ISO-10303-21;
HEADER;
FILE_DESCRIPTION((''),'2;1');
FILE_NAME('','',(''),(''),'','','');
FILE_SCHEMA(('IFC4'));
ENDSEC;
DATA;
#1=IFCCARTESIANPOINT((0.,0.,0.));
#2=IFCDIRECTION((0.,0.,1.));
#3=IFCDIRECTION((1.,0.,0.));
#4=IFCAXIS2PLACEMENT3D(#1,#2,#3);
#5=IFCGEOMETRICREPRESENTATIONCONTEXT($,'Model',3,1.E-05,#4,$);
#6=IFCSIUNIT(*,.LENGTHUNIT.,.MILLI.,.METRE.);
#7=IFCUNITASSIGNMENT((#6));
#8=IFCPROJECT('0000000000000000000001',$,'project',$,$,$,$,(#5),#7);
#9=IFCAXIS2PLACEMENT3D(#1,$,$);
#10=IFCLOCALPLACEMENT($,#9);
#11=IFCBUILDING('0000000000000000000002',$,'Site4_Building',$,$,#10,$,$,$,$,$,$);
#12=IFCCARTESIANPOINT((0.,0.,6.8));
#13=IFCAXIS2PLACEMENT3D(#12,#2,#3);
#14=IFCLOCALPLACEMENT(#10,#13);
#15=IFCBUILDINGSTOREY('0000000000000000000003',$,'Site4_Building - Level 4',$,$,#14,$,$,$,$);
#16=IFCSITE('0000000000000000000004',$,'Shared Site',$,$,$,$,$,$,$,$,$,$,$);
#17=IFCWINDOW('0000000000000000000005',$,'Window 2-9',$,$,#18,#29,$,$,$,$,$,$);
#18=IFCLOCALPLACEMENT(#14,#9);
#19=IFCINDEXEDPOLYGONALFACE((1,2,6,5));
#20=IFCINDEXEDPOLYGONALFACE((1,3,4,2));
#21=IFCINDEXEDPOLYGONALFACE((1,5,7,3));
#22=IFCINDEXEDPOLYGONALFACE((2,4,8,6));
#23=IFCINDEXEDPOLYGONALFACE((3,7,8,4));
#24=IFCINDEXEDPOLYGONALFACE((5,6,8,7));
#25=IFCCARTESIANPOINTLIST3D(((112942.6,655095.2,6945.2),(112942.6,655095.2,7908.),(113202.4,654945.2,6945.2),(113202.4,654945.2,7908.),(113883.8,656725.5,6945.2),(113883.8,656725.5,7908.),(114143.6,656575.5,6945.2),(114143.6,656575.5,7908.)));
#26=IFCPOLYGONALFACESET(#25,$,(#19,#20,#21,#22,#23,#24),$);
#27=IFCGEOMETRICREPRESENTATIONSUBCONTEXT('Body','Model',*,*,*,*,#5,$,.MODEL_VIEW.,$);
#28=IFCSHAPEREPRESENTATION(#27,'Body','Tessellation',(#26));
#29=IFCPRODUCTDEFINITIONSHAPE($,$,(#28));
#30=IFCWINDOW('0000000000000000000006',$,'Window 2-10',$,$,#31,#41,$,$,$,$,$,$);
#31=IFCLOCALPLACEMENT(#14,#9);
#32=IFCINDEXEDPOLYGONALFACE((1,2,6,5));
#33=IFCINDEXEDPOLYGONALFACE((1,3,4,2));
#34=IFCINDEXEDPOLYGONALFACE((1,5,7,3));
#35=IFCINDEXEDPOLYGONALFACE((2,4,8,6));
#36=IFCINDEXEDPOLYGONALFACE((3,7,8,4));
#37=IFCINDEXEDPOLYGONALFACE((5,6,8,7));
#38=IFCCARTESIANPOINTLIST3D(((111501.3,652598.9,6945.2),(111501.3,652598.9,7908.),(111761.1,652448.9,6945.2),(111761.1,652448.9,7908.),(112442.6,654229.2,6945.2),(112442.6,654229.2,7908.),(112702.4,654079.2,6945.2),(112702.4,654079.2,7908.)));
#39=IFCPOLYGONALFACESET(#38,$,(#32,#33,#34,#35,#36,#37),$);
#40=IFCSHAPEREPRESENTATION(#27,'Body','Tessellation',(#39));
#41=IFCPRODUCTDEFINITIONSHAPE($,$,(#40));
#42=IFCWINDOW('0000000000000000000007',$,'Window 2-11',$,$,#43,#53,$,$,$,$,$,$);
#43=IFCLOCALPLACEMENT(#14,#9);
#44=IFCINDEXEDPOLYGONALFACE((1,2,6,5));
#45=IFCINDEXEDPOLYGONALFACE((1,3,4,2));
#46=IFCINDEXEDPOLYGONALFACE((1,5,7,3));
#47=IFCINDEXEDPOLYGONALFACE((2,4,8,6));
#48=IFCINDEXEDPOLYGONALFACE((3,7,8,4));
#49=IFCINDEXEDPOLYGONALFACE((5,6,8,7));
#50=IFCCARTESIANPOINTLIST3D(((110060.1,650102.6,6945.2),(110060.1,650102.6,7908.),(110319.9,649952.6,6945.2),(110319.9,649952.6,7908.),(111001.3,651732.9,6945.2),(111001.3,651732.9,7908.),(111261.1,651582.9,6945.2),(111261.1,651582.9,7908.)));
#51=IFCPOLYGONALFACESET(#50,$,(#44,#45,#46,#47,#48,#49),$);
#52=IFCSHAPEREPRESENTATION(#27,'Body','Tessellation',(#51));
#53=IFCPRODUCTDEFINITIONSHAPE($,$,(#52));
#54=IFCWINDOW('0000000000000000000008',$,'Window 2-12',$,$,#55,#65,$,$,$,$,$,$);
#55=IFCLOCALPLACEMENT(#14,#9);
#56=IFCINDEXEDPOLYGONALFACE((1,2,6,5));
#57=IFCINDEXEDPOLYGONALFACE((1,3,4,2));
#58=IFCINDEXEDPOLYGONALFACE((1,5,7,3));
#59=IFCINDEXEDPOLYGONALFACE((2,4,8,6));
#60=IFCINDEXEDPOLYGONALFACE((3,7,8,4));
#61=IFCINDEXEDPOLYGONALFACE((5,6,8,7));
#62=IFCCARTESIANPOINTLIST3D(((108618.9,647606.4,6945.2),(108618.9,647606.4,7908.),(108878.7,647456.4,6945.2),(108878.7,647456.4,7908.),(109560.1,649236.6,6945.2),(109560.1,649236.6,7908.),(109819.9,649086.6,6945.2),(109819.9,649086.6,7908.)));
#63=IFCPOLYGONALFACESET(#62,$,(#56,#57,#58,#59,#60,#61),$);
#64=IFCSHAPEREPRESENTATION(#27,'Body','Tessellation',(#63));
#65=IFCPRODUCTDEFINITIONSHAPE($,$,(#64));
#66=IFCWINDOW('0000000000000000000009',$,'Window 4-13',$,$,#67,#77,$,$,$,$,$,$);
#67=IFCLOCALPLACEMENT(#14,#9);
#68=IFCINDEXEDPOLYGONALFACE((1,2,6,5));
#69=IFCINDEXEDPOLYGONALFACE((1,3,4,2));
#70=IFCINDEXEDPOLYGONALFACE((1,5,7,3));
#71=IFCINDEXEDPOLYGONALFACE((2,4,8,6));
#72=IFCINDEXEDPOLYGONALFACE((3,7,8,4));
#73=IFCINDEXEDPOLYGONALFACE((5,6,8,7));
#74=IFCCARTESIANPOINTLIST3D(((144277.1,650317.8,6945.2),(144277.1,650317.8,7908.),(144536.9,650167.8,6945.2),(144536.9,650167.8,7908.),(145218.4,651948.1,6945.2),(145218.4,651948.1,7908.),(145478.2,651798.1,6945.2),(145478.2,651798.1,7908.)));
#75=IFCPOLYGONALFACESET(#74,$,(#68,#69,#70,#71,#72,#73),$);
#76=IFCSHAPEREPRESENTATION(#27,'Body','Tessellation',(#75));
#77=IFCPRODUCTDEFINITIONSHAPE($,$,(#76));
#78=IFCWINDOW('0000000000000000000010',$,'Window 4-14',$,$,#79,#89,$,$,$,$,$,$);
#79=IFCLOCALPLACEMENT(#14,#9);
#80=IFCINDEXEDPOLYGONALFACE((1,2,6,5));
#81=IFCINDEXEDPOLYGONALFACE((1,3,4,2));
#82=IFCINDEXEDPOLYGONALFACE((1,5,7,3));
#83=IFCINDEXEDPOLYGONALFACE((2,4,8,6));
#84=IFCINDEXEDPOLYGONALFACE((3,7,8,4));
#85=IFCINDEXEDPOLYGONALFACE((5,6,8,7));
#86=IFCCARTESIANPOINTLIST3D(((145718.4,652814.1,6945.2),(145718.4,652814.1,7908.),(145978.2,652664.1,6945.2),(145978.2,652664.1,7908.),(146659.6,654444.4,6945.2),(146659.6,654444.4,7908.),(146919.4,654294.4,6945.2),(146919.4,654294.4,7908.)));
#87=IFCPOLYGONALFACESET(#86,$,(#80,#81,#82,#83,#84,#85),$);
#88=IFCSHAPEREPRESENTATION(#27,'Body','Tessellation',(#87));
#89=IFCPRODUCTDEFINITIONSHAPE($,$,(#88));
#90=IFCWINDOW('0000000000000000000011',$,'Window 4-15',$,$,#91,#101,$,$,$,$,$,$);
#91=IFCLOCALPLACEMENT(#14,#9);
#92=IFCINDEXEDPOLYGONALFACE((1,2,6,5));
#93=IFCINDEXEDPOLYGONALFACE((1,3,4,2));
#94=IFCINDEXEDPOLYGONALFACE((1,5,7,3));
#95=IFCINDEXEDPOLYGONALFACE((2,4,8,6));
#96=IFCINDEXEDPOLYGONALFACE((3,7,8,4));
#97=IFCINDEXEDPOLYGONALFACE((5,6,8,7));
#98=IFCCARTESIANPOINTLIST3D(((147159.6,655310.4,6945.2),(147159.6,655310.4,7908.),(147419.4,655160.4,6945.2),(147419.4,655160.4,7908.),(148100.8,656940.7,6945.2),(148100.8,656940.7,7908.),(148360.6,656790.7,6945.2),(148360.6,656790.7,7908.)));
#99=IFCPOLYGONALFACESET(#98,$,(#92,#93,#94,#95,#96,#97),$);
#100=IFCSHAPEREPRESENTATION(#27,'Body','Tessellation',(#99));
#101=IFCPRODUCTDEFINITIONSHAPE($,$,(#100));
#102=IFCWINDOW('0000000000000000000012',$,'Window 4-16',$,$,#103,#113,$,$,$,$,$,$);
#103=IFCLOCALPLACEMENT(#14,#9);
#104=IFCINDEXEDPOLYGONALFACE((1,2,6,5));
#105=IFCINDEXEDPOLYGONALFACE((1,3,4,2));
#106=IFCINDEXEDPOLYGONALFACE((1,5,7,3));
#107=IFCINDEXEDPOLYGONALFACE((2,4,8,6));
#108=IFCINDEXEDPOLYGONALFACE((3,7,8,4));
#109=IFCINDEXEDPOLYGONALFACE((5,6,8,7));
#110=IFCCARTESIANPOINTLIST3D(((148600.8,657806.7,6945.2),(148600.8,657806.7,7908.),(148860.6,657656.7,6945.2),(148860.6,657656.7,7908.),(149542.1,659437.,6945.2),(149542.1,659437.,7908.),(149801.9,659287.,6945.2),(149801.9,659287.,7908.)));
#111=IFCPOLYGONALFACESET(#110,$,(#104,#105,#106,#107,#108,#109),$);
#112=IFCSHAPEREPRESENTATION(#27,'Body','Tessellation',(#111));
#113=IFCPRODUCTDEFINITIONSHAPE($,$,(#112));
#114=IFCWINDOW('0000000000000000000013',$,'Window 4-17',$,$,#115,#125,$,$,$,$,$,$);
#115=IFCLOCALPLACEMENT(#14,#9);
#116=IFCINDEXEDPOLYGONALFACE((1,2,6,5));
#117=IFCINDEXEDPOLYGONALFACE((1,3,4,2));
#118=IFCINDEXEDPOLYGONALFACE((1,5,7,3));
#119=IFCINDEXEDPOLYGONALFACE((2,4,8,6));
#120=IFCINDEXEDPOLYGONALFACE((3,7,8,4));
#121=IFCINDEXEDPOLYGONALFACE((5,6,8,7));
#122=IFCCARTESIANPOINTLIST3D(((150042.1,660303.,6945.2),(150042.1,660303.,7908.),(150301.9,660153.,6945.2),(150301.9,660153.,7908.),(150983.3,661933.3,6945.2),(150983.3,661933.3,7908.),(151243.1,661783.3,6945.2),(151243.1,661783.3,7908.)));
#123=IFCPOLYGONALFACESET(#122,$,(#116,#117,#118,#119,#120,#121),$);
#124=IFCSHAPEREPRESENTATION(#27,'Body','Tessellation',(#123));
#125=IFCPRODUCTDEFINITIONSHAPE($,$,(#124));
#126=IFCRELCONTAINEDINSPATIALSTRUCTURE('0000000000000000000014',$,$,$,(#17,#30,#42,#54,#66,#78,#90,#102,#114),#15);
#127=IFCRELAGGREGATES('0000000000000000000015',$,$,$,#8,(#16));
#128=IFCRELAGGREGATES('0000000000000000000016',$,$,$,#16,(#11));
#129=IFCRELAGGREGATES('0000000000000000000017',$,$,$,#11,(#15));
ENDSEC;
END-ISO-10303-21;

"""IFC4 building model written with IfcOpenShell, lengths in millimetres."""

from ifc_helpers import new_model, si_unit, frame, origin, origin_with_axes, place, context, subcontext, project, spatial, indexed_curve, outline, extrude, element, save


model = new_model("IFC4")

# Units and contexts
model_context = context("Model", 3, precision=1e-05, world=origin_with_axes())
body_context = subcontext(model_context, "Body", "Model", "MODEL_VIEW")
ifc_project = project(units=[si_unit("LENGTHUNIT", "METRE", prefix="MILLI")], contexts=[model_context])

# Site, building, storey
site = spatial("IfcSite", under=ifc_project, Name="Shared Site")
building_placement = place(None, origin())
building = spatial("IfcBuilding", under=site, at=building_placement, Name="Site4_Building")
storey_placement = place(building_placement, frame((0.0, 0.0, 6.8), z_axis=(0.0, 0.0, 1.0), x_axis=(1.0, 0.0, 0.0)))
storey = spatial("IfcBuildingStorey", under=building, at=storey_placement, Name="Site4_Building - Level 4")

# Windows
for number, where, z_axis, x_axis, name in (
    (1, (113883.8, 656725.5, 6945.2), (0.0, 0.0, 1.0), (-0.5, -0.866025, 0.0), "Window 2-9"),
    (2, (112442.6, 654229.2, 6945.2), (0.0, 0.0, 1.0), (-0.5, -0.866025, 0.0), "Window 2-10"),
    (3, (111001.3, 651732.9, 6945.2), (0.0, 0.0, 1.0), (-0.5, -0.866025, 0.0), "Window 2-11"),
    (4, (109560.1, 649236.6, 6945.2), (0.0, 0.0, 1.0), (-0.5, -0.866025, 0.0), "Window 2-12"),
    (5, (144536.9, 650167.8, 6945.2), (0.0, 0.0, 1.0), (0.5, 0.866025, 0.0), "Window 4-13"),
    (6, (145978.2, 652664.1, 6945.2), (0.0, 0.0, 1.0), (0.5, 0.866025, 0.0), "Window 4-14"),
    (7, (147419.4, 655160.4, 6945.2), (0.0, 0.0, 1.0), (0.5, 0.866025, 0.0), "Window 4-15"),
    (8, (148860.6, 657656.7, 6945.2), (0.0, 0.0, 1.0), (0.5, 0.866025, 0.0), "Window 4-16"),
    (9, (150301.9, 660153.0, 6945.2), (0.0, 0.0, 1.0), (0.5, 0.866025, 0.0), "Window 4-17"),
):
    element("IfcWindow", number, at=place(storey_placement, frame(where, z_axis=z_axis, x_axis=x_axis)), inside=storey, Name=name, context=body_context, shape_type="SweptSolid", body=[
        extrude(outline(indexed_curve([(0.0, 0.0), (0.0, 300.0), (1882.5, 300.0), (1882.5, 0.0), (0.0, 0.0)], self_intersect=False)), origin_with_axes(), (0.0, 0.0, 1.0), 962.8),
    ])

save(model, "model.ifc")
